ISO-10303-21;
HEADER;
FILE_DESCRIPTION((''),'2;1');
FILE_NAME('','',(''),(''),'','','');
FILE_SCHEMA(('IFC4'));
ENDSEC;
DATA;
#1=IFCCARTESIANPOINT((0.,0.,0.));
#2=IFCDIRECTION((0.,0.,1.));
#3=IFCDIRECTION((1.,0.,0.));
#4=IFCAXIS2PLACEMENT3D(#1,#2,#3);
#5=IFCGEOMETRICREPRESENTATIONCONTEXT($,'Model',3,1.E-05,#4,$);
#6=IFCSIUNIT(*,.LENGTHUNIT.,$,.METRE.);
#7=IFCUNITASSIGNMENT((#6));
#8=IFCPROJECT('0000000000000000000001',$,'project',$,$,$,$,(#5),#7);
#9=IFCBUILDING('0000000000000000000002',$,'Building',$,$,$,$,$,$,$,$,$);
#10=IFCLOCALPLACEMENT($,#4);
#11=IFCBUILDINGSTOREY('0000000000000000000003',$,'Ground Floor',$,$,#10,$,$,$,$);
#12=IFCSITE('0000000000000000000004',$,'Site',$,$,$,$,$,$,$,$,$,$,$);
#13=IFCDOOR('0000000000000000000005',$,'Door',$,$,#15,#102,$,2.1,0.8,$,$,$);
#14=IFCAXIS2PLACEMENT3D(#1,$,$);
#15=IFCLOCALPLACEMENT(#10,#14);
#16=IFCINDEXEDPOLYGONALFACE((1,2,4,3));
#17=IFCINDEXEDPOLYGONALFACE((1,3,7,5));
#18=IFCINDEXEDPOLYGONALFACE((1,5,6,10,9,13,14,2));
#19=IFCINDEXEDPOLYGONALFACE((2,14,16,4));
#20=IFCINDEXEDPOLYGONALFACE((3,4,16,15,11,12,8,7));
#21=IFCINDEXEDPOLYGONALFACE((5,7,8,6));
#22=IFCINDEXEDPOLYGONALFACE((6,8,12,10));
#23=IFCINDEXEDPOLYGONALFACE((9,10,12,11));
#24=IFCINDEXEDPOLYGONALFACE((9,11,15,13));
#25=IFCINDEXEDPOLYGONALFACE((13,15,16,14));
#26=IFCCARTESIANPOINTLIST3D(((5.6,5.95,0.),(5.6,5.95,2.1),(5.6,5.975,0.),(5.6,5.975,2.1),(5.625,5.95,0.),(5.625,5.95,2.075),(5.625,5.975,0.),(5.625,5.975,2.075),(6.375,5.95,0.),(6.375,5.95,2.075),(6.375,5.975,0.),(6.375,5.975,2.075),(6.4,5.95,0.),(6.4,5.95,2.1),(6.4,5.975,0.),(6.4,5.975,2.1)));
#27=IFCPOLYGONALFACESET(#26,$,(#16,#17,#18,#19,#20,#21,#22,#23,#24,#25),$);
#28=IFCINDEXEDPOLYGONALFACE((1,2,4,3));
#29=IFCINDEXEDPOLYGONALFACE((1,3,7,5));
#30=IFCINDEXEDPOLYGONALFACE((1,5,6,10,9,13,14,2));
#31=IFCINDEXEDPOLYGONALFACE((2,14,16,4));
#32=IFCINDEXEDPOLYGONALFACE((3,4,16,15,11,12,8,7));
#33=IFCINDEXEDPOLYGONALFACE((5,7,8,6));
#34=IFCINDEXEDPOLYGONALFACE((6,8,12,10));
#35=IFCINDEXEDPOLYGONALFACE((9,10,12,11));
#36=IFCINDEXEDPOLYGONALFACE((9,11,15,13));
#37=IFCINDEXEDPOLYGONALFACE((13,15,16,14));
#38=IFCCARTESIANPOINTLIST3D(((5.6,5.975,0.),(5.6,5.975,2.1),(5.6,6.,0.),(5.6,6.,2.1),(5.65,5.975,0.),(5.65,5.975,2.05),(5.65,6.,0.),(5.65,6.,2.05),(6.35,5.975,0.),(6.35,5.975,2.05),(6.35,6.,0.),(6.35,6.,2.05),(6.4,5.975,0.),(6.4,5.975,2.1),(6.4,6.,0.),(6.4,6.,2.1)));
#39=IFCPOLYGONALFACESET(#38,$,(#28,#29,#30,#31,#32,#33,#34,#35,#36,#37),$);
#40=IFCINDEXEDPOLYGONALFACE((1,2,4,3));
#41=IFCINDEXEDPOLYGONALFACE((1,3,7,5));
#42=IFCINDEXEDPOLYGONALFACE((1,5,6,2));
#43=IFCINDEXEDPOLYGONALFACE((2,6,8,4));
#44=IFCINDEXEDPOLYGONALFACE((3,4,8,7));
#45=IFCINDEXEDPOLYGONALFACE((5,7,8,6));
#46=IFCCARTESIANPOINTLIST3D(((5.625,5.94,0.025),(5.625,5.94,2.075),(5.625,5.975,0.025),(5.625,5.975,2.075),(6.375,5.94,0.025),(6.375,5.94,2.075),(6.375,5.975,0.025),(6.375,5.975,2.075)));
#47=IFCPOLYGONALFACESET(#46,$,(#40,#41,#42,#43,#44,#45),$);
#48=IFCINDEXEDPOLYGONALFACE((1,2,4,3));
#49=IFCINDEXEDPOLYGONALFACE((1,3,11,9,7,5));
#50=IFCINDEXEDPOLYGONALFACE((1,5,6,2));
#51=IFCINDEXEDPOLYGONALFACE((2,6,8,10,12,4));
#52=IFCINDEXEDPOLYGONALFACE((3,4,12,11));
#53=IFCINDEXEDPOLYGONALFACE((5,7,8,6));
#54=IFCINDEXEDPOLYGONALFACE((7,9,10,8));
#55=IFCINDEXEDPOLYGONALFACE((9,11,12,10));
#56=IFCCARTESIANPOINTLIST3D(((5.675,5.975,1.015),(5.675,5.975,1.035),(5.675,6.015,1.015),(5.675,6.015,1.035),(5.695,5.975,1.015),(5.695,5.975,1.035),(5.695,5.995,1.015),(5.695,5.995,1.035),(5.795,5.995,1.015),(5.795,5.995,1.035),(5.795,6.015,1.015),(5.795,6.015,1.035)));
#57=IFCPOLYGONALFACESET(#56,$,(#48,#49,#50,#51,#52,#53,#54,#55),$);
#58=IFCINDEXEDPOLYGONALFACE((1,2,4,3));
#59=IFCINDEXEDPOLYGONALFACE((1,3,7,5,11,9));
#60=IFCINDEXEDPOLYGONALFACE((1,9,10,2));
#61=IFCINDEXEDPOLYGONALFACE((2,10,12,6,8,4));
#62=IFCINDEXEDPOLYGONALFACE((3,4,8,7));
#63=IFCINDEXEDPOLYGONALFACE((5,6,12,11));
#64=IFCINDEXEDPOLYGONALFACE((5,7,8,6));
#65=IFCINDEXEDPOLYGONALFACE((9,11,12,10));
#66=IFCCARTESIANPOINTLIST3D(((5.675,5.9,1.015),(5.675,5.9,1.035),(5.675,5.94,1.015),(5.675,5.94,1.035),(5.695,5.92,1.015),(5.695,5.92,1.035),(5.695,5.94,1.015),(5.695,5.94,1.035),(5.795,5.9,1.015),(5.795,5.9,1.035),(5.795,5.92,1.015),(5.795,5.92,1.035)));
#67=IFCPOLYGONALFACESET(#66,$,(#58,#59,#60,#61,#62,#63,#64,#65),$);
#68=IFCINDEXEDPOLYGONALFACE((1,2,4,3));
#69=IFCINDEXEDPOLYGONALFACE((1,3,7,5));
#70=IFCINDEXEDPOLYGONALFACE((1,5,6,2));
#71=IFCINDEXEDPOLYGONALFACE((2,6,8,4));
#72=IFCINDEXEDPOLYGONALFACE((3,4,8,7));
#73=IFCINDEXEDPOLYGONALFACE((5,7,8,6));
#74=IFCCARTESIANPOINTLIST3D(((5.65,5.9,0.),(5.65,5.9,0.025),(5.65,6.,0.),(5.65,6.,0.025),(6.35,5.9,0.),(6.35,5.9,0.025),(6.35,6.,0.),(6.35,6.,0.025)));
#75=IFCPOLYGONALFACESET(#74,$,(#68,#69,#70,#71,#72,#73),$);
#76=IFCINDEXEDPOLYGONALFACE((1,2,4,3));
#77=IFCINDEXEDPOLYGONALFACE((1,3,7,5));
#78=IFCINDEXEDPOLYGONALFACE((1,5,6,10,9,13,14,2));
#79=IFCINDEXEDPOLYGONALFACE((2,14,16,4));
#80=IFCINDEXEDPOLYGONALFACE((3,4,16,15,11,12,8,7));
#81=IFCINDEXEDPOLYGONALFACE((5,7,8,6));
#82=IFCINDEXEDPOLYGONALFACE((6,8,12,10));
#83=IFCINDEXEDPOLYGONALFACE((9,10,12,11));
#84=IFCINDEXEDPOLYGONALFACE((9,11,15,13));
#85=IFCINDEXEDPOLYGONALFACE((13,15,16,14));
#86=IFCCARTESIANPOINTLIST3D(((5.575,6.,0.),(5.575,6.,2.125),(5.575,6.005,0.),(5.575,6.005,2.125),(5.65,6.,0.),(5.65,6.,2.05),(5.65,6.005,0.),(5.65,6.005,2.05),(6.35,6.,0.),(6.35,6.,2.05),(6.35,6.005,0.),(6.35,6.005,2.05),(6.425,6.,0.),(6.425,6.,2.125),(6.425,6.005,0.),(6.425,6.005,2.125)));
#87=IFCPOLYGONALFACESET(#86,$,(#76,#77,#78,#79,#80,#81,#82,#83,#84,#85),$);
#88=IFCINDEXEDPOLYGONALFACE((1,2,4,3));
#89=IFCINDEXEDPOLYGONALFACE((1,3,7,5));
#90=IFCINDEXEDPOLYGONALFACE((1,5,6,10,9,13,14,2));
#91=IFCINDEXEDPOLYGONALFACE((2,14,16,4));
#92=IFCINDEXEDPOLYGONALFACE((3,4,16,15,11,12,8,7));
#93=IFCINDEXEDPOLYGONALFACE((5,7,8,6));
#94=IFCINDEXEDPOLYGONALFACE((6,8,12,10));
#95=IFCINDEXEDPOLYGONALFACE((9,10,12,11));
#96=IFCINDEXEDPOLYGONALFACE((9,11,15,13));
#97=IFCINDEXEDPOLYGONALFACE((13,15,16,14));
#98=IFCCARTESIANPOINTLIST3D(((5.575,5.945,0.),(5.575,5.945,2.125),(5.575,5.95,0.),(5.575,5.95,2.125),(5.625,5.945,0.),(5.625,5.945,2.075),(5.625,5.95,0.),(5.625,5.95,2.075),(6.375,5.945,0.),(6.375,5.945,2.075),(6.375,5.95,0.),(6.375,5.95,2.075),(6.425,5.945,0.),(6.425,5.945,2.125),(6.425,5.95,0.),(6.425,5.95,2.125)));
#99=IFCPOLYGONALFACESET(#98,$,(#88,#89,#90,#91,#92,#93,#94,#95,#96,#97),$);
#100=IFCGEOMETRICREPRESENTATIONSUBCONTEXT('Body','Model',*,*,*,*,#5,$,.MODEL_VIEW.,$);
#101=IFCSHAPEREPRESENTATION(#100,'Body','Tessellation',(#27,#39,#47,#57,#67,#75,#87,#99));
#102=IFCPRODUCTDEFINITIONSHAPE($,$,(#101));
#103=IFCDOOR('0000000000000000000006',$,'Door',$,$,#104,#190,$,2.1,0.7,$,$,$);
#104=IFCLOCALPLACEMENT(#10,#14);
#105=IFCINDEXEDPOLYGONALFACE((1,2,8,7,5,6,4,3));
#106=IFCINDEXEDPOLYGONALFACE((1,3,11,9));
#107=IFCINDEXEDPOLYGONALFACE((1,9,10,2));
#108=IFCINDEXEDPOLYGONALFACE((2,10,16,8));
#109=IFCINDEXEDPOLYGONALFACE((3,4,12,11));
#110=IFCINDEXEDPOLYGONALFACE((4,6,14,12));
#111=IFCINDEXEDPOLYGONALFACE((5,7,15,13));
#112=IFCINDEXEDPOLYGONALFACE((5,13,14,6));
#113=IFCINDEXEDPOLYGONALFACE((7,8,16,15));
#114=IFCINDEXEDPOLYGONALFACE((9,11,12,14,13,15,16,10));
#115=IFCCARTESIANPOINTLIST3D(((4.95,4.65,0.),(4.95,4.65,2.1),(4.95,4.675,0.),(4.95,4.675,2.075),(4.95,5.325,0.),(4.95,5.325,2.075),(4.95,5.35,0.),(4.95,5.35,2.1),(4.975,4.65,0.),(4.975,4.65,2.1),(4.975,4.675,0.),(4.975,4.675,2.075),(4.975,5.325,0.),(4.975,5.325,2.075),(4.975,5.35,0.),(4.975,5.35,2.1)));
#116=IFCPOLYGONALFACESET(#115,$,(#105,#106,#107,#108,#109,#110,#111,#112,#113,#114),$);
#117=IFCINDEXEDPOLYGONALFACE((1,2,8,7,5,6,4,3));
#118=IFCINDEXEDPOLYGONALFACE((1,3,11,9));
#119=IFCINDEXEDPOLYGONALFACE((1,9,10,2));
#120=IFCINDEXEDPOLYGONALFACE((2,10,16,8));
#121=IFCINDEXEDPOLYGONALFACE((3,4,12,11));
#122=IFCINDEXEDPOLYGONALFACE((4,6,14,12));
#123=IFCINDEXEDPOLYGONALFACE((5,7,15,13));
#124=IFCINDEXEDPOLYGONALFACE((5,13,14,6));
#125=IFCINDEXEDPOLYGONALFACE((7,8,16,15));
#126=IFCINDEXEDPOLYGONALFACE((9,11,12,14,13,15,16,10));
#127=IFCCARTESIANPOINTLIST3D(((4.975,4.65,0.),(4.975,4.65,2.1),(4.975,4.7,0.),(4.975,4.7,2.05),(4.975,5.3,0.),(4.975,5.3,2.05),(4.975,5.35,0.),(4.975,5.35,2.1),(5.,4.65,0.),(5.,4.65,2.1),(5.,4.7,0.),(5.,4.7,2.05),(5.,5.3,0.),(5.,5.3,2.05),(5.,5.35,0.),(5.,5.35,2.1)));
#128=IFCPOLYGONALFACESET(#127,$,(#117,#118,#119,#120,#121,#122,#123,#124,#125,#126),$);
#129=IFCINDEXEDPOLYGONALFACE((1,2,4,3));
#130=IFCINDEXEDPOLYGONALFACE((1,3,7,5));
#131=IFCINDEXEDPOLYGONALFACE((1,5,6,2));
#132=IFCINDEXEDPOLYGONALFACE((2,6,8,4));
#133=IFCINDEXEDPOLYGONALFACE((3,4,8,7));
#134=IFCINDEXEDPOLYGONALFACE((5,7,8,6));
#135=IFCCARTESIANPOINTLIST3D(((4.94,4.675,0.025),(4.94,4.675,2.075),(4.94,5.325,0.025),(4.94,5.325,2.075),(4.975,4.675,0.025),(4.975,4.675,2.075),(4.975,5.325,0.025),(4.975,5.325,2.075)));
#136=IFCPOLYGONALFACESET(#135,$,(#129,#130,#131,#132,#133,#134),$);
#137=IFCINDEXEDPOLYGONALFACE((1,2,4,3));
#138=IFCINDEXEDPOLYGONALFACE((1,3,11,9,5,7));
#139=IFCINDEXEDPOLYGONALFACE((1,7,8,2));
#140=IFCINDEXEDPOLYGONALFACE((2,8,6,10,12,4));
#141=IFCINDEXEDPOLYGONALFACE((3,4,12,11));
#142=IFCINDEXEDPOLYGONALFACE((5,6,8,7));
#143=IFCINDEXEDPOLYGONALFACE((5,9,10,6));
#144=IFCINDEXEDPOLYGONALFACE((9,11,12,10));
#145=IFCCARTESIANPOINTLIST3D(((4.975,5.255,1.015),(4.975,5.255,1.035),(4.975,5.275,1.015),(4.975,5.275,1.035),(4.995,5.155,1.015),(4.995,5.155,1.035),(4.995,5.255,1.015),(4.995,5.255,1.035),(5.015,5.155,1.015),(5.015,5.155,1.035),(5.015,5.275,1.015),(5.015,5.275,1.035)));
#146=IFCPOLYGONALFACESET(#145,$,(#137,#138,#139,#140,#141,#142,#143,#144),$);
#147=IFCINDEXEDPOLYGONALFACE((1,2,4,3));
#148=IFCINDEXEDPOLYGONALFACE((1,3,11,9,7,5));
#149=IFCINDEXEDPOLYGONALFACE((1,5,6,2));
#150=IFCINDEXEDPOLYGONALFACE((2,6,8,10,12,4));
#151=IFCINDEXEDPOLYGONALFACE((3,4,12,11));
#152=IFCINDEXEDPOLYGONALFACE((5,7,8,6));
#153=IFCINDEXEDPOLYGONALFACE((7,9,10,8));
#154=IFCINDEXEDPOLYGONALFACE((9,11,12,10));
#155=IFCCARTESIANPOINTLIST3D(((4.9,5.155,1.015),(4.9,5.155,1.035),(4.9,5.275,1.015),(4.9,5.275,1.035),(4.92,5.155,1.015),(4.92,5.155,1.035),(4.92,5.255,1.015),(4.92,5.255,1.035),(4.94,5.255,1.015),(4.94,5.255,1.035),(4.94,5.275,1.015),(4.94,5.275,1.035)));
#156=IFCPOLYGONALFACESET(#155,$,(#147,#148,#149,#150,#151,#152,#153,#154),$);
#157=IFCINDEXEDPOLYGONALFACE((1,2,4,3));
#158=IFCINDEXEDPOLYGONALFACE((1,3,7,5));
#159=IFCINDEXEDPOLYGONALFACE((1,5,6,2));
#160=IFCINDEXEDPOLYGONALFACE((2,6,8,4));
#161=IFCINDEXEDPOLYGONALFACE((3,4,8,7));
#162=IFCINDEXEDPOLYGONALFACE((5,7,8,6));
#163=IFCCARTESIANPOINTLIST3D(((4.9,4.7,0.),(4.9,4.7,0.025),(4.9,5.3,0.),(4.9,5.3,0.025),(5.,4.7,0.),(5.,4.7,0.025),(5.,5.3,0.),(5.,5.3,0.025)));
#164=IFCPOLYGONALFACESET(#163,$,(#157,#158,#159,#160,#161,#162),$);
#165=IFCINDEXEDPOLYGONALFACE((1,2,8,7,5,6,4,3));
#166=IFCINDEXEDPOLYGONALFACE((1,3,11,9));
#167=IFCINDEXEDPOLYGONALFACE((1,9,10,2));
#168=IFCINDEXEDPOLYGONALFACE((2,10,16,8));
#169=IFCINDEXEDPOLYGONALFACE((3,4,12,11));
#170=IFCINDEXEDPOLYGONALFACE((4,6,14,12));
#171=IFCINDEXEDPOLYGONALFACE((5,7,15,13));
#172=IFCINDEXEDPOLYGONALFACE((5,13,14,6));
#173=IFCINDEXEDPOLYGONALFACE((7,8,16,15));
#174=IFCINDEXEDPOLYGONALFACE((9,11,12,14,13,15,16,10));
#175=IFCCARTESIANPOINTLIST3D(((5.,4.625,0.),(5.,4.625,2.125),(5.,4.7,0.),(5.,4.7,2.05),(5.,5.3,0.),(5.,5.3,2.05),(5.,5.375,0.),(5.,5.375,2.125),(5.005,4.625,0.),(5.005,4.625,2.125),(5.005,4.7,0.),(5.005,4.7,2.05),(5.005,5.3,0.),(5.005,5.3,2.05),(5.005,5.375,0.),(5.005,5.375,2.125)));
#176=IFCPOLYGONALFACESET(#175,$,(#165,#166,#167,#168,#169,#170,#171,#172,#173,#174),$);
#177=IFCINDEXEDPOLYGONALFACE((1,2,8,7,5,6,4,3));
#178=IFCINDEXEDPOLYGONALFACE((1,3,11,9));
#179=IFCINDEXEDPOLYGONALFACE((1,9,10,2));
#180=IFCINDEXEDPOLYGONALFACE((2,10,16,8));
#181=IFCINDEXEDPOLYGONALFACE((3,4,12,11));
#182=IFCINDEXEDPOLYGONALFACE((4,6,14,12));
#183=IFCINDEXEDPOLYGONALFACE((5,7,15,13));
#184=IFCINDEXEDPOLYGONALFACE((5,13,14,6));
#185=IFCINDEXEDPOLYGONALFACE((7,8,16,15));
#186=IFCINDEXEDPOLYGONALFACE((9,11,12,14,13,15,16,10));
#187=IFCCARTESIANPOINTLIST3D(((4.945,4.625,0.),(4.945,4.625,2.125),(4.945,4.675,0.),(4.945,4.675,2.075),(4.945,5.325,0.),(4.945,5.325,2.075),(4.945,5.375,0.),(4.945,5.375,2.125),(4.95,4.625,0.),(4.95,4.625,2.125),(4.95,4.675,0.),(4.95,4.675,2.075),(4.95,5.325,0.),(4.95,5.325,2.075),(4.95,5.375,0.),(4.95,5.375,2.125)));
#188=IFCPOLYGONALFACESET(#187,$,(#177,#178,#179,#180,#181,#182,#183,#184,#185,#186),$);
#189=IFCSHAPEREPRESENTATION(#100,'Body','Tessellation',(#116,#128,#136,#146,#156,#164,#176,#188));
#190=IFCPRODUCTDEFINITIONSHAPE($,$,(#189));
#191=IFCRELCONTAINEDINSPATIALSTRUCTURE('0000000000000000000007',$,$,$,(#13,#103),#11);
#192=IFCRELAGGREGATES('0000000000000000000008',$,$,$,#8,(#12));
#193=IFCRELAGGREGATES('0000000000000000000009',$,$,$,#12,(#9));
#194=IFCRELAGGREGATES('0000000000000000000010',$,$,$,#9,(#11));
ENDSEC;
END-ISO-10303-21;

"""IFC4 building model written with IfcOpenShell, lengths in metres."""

from ifc_helpers import new_model, si_unit, frame, origin_with_axes, place, context, subcontext, project, spatial, line, indexed_curve, outline, extrude, element, save


model = new_model("IFC4")

# Units and contexts
model_context = context("Model", 3, precision=1e-05, world=origin_with_axes())
body_context = subcontext(model_context, "Body", "Model", "MODEL_VIEW")
ifc_project = project(units=[si_unit("LENGTHUNIT", "METRE")], contexts=[model_context])

# Site, building, storey
site = spatial("IfcSite", under=ifc_project, Name="Site")
building = spatial("IfcBuilding", under=site, Name="Building")
storey_placement = place(None, origin_with_axes())
storey = spatial("IfcBuildingStorey", under=building, at=storey_placement, Name="Ground Floor")

# Doors
door_1_placement = place(storey_placement, frame((6.4, 6.0, 0.0), z_axis=(0.0, 0.0, 1.0), x_axis=(-1.0, 0.0, 0.0)))
element("IfcDoor", 1, at=door_1_placement, inside=storey, Name="Door", OverallHeight=2.1, OverallWidth=0.8, context=body_context, shape_type="SweptSolid", body=[
    extrude(outline(indexed_curve([(0.0, 0.0), (0.0, 2.1), (0.8, 2.1), (0.8, 0.0), (0.775, 0.0), (0.775, 2.075), (0.025, 2.075), (0.025, 0.0)], segments=[line(1, 2, 3, 4, 5, 6, 7, 8, 1)])), frame((0.0, 0.025, 0.0), z_axis=(0.0, -1.0, 0.0), x_axis=(1.0, 0.0, 0.0)), (0.0, 0.0, -1.0), 0.025),
    extrude(outline(indexed_curve([(0.0, 0.0), (0.0, 2.1), (0.8, 2.1), (0.8, 0.0), (0.75, 0.0), (0.75, 2.05), (0.05, 2.05), (0.05, 0.0)], segments=[line(1, 2, 3, 4, 5, 6, 7, 8, 1)])), frame((0.0, 0.0, 0.0), z_axis=(0.0, -1.0, 0.0), x_axis=(1.0, 0.0, 0.0)), (0.0, 0.0, -1.0), 0.025),
    extrude(outline(indexed_curve([(0.0, 0.0), (0.75, 0.0), (0.75, 0.035), (0.0, 0.035)], segments=[line(1, 2, 3, 4, 1)])), frame((0.025, 0.025, 0.025), z_axis=(0.0, 0.0, 1.0), x_axis=(1.0, 0.0, 0.0)), (0.0, 0.0, 1.0), 2.05),
    extrude(outline(indexed_curve([(0.0, 0.0), (0.0, -0.04), (-0.12, -0.04), (-0.12, -0.02), (-0.02, -0.02), (-0.02, 0.0)], segments=[line(1, 2, 3, 4, 5, 6, 1)])), frame((0.725, 0.025, 1.015), z_axis=(0.0, 0.0, 1.0), x_axis=(1.0, 0.0, 0.0)), (0.0, 0.0, 1.0), 0.02),
    extrude(outline(indexed_curve([(0.0, 0.0), (0.0, 0.04), (-0.12, 0.04), (-0.12, 0.02), (-0.02, 0.02), (-0.02, 0.0)], segments=[line(1, 2, 3, 4, 5, 6, 1)])), frame((0.725, 0.06, 1.015), z_axis=(0.0, 0.0, 1.0), x_axis=(1.0, 0.0, 0.0)), (0.0, 0.0, 1.0), 0.02),
    extrude(outline(indexed_curve([(0.0, 0.0), (0.7, 0.0), (0.7, 0.1), (0.0, 0.1)], segments=[line(1, 2, 3, 4, 1)])), frame((0.05, 0.0, 0.0), z_axis=(0.0, 0.0, 1.0), x_axis=(1.0, 0.0, 0.0)), (0.0, 0.0, 1.0), 0.025),
    extrude(outline(indexed_curve([(0.0, 0.0), (0.0, 2.125), (0.85, 2.125), (0.85, 0.0), (0.775, 0.0), (0.775, 2.05), (0.075, 2.05), (0.075, 0.0)], segments=[line(1, 2, 3, 4, 5, 6, 7, 8, 1)])), frame((-0.025, -0.005, 0.0), z_axis=(0.0, -1.0, 0.0), x_axis=(1.0, 0.0, 0.0)), (0.0, 0.0, -1.0), 0.005),
    extrude(outline(indexed_curve([(0.0, 0.0), (0.0, 2.125), (0.85, 2.125), (0.85, 0.0), (0.8, 0.0), (0.8, 2.075), (0.05, 2.075), (0.05, 0.0)], segments=[line(1, 2, 3, 4, 5, 6, 7, 8, 1)])), frame((-0.025, 0.05, 0.0), z_axis=(0.0, -1.0, 0.0), x_axis=(1.0, 0.0, 0.0)), (0.0, 0.0, -1.0), 0.005),
])
door_2_placement = place(storey_placement, frame((5.0, 4.65, 0.0), z_axis=(0.0, 0.0, 1.0), x_axis=(0.0, 1.0, 0.0)))
element("IfcDoor", 2, at=door_2_placement, inside=storey, Name="Door", OverallHeight=2.1, OverallWidth=0.7, context=body_context, shape_type="SweptSolid", body=[
    extrude(outline(indexed_curve([(0.0, 0.0), (0.0, 2.1), (0.7, 2.1), (0.7, 0.0), (0.675, 0.0), (0.675, 2.075), (0.025, 2.075), (0.025, 0.0)], segments=[line(1, 2, 3, 4, 5, 6, 7, 8, 1)])), frame((0.0, 0.025, 0.0), z_axis=(0.0, -1.0, 0.0), x_axis=(1.0, 0.0, 0.0)), (0.0, 0.0, -1.0), 0.025),
    extrude(outline(indexed_curve([(0.0, 0.0), (0.0, 2.1), (0.7, 2.1), (0.7, 0.0), (0.65, 0.0), (0.65, 2.05), (0.05, 2.05), (0.05, 0.0)], segments=[line(1, 2, 3, 4, 5, 6, 7, 8, 1)])), frame((0.0, 0.0, 0.0), z_axis=(0.0, -1.0, 0.0), x_axis=(1.0, 0.0, 0.0)), (0.0, 0.0, -1.0), 0.025),
    extrude(outline(indexed_curve([(0.0, 0.0), (0.65, 0.0), (0.65, 0.035), (0.0, 0.035)], segments=[line(1, 2, 3, 4, 1)])), frame((0.025, 0.025, 0.025), z_axis=(0.0, 0.0, 1.0), x_axis=(1.0, 0.0, 0.0)), (0.0, 0.0, 1.0), 2.05),
    extrude(outline(indexed_curve([(0.0, 0.0), (0.0, -0.04), (-0.12, -0.04), (-0.12, -0.02), (-0.02, -0.02), (-0.02, 0.0)], segments=[line(1, 2, 3, 4, 5, 6, 1)])), frame((0.625, 0.025, 1.015), z_axis=(0.0, 0.0, 1.0), x_axis=(1.0, 0.0, 0.0)), (0.0, 0.0, 1.0), 0.02),
    extrude(outline(indexed_curve([(0.0, 0.0), (0.0, 0.04), (-0.12, 0.04), (-0.12, 0.02), (-0.02, 0.02), (-0.02, 0.0)], segments=[line(1, 2, 3, 4, 5, 6, 1)])), frame((0.625, 0.06, 1.015), z_axis=(0.0, 0.0, 1.0), x_axis=(1.0, 0.0, 0.0)), (0.0, 0.0, 1.0), 0.02),
    extrude(outline(indexed_curve([(0.0, 0.0), (0.6, 0.0), (0.6, 0.1), (0.0, 0.1)], segments=[line(1, 2, 3, 4, 1)])), frame((0.05, 0.0, 0.0), z_axis=(0.0, 0.0, 1.0), x_axis=(1.0, 0.0, 0.0)), (0.0, 0.0, 1.0), 0.025),
    extrude(outline(indexed_curve([(0.0, 0.0), (0.0, 2.125), (0.75, 2.125), (0.75, 0.0), (0.675, 0.0), (0.675, 2.05), (0.075, 2.05), (0.075, 0.0)], segments=[line(1, 2, 3, 4, 5, 6, 7, 8, 1)])), frame((-0.025, -0.005, 0.0), z_axis=(0.0, -1.0, 0.0), x_axis=(1.0, 0.0, 0.0)), (0.0, 0.0, -1.0), 0.005),
    extrude(outline(indexed_curve([(0.0, 0.0), (0.0, 2.125), (0.75, 2.125), (0.75, 0.0), (0.7, 0.0), (0.7, 2.075), (0.05, 2.075), (0.05, 0.0)], segments=[line(1, 2, 3, 4, 5, 6, 7, 8, 1)])), frame((-0.025, 0.05, 0.0), z_axis=(0.0, -1.0, 0.0), x_axis=(1.0, 0.0, 0.0)), (0.0, 0.0, -1.0), 0.005),
])

save(model, "model.ifc")
